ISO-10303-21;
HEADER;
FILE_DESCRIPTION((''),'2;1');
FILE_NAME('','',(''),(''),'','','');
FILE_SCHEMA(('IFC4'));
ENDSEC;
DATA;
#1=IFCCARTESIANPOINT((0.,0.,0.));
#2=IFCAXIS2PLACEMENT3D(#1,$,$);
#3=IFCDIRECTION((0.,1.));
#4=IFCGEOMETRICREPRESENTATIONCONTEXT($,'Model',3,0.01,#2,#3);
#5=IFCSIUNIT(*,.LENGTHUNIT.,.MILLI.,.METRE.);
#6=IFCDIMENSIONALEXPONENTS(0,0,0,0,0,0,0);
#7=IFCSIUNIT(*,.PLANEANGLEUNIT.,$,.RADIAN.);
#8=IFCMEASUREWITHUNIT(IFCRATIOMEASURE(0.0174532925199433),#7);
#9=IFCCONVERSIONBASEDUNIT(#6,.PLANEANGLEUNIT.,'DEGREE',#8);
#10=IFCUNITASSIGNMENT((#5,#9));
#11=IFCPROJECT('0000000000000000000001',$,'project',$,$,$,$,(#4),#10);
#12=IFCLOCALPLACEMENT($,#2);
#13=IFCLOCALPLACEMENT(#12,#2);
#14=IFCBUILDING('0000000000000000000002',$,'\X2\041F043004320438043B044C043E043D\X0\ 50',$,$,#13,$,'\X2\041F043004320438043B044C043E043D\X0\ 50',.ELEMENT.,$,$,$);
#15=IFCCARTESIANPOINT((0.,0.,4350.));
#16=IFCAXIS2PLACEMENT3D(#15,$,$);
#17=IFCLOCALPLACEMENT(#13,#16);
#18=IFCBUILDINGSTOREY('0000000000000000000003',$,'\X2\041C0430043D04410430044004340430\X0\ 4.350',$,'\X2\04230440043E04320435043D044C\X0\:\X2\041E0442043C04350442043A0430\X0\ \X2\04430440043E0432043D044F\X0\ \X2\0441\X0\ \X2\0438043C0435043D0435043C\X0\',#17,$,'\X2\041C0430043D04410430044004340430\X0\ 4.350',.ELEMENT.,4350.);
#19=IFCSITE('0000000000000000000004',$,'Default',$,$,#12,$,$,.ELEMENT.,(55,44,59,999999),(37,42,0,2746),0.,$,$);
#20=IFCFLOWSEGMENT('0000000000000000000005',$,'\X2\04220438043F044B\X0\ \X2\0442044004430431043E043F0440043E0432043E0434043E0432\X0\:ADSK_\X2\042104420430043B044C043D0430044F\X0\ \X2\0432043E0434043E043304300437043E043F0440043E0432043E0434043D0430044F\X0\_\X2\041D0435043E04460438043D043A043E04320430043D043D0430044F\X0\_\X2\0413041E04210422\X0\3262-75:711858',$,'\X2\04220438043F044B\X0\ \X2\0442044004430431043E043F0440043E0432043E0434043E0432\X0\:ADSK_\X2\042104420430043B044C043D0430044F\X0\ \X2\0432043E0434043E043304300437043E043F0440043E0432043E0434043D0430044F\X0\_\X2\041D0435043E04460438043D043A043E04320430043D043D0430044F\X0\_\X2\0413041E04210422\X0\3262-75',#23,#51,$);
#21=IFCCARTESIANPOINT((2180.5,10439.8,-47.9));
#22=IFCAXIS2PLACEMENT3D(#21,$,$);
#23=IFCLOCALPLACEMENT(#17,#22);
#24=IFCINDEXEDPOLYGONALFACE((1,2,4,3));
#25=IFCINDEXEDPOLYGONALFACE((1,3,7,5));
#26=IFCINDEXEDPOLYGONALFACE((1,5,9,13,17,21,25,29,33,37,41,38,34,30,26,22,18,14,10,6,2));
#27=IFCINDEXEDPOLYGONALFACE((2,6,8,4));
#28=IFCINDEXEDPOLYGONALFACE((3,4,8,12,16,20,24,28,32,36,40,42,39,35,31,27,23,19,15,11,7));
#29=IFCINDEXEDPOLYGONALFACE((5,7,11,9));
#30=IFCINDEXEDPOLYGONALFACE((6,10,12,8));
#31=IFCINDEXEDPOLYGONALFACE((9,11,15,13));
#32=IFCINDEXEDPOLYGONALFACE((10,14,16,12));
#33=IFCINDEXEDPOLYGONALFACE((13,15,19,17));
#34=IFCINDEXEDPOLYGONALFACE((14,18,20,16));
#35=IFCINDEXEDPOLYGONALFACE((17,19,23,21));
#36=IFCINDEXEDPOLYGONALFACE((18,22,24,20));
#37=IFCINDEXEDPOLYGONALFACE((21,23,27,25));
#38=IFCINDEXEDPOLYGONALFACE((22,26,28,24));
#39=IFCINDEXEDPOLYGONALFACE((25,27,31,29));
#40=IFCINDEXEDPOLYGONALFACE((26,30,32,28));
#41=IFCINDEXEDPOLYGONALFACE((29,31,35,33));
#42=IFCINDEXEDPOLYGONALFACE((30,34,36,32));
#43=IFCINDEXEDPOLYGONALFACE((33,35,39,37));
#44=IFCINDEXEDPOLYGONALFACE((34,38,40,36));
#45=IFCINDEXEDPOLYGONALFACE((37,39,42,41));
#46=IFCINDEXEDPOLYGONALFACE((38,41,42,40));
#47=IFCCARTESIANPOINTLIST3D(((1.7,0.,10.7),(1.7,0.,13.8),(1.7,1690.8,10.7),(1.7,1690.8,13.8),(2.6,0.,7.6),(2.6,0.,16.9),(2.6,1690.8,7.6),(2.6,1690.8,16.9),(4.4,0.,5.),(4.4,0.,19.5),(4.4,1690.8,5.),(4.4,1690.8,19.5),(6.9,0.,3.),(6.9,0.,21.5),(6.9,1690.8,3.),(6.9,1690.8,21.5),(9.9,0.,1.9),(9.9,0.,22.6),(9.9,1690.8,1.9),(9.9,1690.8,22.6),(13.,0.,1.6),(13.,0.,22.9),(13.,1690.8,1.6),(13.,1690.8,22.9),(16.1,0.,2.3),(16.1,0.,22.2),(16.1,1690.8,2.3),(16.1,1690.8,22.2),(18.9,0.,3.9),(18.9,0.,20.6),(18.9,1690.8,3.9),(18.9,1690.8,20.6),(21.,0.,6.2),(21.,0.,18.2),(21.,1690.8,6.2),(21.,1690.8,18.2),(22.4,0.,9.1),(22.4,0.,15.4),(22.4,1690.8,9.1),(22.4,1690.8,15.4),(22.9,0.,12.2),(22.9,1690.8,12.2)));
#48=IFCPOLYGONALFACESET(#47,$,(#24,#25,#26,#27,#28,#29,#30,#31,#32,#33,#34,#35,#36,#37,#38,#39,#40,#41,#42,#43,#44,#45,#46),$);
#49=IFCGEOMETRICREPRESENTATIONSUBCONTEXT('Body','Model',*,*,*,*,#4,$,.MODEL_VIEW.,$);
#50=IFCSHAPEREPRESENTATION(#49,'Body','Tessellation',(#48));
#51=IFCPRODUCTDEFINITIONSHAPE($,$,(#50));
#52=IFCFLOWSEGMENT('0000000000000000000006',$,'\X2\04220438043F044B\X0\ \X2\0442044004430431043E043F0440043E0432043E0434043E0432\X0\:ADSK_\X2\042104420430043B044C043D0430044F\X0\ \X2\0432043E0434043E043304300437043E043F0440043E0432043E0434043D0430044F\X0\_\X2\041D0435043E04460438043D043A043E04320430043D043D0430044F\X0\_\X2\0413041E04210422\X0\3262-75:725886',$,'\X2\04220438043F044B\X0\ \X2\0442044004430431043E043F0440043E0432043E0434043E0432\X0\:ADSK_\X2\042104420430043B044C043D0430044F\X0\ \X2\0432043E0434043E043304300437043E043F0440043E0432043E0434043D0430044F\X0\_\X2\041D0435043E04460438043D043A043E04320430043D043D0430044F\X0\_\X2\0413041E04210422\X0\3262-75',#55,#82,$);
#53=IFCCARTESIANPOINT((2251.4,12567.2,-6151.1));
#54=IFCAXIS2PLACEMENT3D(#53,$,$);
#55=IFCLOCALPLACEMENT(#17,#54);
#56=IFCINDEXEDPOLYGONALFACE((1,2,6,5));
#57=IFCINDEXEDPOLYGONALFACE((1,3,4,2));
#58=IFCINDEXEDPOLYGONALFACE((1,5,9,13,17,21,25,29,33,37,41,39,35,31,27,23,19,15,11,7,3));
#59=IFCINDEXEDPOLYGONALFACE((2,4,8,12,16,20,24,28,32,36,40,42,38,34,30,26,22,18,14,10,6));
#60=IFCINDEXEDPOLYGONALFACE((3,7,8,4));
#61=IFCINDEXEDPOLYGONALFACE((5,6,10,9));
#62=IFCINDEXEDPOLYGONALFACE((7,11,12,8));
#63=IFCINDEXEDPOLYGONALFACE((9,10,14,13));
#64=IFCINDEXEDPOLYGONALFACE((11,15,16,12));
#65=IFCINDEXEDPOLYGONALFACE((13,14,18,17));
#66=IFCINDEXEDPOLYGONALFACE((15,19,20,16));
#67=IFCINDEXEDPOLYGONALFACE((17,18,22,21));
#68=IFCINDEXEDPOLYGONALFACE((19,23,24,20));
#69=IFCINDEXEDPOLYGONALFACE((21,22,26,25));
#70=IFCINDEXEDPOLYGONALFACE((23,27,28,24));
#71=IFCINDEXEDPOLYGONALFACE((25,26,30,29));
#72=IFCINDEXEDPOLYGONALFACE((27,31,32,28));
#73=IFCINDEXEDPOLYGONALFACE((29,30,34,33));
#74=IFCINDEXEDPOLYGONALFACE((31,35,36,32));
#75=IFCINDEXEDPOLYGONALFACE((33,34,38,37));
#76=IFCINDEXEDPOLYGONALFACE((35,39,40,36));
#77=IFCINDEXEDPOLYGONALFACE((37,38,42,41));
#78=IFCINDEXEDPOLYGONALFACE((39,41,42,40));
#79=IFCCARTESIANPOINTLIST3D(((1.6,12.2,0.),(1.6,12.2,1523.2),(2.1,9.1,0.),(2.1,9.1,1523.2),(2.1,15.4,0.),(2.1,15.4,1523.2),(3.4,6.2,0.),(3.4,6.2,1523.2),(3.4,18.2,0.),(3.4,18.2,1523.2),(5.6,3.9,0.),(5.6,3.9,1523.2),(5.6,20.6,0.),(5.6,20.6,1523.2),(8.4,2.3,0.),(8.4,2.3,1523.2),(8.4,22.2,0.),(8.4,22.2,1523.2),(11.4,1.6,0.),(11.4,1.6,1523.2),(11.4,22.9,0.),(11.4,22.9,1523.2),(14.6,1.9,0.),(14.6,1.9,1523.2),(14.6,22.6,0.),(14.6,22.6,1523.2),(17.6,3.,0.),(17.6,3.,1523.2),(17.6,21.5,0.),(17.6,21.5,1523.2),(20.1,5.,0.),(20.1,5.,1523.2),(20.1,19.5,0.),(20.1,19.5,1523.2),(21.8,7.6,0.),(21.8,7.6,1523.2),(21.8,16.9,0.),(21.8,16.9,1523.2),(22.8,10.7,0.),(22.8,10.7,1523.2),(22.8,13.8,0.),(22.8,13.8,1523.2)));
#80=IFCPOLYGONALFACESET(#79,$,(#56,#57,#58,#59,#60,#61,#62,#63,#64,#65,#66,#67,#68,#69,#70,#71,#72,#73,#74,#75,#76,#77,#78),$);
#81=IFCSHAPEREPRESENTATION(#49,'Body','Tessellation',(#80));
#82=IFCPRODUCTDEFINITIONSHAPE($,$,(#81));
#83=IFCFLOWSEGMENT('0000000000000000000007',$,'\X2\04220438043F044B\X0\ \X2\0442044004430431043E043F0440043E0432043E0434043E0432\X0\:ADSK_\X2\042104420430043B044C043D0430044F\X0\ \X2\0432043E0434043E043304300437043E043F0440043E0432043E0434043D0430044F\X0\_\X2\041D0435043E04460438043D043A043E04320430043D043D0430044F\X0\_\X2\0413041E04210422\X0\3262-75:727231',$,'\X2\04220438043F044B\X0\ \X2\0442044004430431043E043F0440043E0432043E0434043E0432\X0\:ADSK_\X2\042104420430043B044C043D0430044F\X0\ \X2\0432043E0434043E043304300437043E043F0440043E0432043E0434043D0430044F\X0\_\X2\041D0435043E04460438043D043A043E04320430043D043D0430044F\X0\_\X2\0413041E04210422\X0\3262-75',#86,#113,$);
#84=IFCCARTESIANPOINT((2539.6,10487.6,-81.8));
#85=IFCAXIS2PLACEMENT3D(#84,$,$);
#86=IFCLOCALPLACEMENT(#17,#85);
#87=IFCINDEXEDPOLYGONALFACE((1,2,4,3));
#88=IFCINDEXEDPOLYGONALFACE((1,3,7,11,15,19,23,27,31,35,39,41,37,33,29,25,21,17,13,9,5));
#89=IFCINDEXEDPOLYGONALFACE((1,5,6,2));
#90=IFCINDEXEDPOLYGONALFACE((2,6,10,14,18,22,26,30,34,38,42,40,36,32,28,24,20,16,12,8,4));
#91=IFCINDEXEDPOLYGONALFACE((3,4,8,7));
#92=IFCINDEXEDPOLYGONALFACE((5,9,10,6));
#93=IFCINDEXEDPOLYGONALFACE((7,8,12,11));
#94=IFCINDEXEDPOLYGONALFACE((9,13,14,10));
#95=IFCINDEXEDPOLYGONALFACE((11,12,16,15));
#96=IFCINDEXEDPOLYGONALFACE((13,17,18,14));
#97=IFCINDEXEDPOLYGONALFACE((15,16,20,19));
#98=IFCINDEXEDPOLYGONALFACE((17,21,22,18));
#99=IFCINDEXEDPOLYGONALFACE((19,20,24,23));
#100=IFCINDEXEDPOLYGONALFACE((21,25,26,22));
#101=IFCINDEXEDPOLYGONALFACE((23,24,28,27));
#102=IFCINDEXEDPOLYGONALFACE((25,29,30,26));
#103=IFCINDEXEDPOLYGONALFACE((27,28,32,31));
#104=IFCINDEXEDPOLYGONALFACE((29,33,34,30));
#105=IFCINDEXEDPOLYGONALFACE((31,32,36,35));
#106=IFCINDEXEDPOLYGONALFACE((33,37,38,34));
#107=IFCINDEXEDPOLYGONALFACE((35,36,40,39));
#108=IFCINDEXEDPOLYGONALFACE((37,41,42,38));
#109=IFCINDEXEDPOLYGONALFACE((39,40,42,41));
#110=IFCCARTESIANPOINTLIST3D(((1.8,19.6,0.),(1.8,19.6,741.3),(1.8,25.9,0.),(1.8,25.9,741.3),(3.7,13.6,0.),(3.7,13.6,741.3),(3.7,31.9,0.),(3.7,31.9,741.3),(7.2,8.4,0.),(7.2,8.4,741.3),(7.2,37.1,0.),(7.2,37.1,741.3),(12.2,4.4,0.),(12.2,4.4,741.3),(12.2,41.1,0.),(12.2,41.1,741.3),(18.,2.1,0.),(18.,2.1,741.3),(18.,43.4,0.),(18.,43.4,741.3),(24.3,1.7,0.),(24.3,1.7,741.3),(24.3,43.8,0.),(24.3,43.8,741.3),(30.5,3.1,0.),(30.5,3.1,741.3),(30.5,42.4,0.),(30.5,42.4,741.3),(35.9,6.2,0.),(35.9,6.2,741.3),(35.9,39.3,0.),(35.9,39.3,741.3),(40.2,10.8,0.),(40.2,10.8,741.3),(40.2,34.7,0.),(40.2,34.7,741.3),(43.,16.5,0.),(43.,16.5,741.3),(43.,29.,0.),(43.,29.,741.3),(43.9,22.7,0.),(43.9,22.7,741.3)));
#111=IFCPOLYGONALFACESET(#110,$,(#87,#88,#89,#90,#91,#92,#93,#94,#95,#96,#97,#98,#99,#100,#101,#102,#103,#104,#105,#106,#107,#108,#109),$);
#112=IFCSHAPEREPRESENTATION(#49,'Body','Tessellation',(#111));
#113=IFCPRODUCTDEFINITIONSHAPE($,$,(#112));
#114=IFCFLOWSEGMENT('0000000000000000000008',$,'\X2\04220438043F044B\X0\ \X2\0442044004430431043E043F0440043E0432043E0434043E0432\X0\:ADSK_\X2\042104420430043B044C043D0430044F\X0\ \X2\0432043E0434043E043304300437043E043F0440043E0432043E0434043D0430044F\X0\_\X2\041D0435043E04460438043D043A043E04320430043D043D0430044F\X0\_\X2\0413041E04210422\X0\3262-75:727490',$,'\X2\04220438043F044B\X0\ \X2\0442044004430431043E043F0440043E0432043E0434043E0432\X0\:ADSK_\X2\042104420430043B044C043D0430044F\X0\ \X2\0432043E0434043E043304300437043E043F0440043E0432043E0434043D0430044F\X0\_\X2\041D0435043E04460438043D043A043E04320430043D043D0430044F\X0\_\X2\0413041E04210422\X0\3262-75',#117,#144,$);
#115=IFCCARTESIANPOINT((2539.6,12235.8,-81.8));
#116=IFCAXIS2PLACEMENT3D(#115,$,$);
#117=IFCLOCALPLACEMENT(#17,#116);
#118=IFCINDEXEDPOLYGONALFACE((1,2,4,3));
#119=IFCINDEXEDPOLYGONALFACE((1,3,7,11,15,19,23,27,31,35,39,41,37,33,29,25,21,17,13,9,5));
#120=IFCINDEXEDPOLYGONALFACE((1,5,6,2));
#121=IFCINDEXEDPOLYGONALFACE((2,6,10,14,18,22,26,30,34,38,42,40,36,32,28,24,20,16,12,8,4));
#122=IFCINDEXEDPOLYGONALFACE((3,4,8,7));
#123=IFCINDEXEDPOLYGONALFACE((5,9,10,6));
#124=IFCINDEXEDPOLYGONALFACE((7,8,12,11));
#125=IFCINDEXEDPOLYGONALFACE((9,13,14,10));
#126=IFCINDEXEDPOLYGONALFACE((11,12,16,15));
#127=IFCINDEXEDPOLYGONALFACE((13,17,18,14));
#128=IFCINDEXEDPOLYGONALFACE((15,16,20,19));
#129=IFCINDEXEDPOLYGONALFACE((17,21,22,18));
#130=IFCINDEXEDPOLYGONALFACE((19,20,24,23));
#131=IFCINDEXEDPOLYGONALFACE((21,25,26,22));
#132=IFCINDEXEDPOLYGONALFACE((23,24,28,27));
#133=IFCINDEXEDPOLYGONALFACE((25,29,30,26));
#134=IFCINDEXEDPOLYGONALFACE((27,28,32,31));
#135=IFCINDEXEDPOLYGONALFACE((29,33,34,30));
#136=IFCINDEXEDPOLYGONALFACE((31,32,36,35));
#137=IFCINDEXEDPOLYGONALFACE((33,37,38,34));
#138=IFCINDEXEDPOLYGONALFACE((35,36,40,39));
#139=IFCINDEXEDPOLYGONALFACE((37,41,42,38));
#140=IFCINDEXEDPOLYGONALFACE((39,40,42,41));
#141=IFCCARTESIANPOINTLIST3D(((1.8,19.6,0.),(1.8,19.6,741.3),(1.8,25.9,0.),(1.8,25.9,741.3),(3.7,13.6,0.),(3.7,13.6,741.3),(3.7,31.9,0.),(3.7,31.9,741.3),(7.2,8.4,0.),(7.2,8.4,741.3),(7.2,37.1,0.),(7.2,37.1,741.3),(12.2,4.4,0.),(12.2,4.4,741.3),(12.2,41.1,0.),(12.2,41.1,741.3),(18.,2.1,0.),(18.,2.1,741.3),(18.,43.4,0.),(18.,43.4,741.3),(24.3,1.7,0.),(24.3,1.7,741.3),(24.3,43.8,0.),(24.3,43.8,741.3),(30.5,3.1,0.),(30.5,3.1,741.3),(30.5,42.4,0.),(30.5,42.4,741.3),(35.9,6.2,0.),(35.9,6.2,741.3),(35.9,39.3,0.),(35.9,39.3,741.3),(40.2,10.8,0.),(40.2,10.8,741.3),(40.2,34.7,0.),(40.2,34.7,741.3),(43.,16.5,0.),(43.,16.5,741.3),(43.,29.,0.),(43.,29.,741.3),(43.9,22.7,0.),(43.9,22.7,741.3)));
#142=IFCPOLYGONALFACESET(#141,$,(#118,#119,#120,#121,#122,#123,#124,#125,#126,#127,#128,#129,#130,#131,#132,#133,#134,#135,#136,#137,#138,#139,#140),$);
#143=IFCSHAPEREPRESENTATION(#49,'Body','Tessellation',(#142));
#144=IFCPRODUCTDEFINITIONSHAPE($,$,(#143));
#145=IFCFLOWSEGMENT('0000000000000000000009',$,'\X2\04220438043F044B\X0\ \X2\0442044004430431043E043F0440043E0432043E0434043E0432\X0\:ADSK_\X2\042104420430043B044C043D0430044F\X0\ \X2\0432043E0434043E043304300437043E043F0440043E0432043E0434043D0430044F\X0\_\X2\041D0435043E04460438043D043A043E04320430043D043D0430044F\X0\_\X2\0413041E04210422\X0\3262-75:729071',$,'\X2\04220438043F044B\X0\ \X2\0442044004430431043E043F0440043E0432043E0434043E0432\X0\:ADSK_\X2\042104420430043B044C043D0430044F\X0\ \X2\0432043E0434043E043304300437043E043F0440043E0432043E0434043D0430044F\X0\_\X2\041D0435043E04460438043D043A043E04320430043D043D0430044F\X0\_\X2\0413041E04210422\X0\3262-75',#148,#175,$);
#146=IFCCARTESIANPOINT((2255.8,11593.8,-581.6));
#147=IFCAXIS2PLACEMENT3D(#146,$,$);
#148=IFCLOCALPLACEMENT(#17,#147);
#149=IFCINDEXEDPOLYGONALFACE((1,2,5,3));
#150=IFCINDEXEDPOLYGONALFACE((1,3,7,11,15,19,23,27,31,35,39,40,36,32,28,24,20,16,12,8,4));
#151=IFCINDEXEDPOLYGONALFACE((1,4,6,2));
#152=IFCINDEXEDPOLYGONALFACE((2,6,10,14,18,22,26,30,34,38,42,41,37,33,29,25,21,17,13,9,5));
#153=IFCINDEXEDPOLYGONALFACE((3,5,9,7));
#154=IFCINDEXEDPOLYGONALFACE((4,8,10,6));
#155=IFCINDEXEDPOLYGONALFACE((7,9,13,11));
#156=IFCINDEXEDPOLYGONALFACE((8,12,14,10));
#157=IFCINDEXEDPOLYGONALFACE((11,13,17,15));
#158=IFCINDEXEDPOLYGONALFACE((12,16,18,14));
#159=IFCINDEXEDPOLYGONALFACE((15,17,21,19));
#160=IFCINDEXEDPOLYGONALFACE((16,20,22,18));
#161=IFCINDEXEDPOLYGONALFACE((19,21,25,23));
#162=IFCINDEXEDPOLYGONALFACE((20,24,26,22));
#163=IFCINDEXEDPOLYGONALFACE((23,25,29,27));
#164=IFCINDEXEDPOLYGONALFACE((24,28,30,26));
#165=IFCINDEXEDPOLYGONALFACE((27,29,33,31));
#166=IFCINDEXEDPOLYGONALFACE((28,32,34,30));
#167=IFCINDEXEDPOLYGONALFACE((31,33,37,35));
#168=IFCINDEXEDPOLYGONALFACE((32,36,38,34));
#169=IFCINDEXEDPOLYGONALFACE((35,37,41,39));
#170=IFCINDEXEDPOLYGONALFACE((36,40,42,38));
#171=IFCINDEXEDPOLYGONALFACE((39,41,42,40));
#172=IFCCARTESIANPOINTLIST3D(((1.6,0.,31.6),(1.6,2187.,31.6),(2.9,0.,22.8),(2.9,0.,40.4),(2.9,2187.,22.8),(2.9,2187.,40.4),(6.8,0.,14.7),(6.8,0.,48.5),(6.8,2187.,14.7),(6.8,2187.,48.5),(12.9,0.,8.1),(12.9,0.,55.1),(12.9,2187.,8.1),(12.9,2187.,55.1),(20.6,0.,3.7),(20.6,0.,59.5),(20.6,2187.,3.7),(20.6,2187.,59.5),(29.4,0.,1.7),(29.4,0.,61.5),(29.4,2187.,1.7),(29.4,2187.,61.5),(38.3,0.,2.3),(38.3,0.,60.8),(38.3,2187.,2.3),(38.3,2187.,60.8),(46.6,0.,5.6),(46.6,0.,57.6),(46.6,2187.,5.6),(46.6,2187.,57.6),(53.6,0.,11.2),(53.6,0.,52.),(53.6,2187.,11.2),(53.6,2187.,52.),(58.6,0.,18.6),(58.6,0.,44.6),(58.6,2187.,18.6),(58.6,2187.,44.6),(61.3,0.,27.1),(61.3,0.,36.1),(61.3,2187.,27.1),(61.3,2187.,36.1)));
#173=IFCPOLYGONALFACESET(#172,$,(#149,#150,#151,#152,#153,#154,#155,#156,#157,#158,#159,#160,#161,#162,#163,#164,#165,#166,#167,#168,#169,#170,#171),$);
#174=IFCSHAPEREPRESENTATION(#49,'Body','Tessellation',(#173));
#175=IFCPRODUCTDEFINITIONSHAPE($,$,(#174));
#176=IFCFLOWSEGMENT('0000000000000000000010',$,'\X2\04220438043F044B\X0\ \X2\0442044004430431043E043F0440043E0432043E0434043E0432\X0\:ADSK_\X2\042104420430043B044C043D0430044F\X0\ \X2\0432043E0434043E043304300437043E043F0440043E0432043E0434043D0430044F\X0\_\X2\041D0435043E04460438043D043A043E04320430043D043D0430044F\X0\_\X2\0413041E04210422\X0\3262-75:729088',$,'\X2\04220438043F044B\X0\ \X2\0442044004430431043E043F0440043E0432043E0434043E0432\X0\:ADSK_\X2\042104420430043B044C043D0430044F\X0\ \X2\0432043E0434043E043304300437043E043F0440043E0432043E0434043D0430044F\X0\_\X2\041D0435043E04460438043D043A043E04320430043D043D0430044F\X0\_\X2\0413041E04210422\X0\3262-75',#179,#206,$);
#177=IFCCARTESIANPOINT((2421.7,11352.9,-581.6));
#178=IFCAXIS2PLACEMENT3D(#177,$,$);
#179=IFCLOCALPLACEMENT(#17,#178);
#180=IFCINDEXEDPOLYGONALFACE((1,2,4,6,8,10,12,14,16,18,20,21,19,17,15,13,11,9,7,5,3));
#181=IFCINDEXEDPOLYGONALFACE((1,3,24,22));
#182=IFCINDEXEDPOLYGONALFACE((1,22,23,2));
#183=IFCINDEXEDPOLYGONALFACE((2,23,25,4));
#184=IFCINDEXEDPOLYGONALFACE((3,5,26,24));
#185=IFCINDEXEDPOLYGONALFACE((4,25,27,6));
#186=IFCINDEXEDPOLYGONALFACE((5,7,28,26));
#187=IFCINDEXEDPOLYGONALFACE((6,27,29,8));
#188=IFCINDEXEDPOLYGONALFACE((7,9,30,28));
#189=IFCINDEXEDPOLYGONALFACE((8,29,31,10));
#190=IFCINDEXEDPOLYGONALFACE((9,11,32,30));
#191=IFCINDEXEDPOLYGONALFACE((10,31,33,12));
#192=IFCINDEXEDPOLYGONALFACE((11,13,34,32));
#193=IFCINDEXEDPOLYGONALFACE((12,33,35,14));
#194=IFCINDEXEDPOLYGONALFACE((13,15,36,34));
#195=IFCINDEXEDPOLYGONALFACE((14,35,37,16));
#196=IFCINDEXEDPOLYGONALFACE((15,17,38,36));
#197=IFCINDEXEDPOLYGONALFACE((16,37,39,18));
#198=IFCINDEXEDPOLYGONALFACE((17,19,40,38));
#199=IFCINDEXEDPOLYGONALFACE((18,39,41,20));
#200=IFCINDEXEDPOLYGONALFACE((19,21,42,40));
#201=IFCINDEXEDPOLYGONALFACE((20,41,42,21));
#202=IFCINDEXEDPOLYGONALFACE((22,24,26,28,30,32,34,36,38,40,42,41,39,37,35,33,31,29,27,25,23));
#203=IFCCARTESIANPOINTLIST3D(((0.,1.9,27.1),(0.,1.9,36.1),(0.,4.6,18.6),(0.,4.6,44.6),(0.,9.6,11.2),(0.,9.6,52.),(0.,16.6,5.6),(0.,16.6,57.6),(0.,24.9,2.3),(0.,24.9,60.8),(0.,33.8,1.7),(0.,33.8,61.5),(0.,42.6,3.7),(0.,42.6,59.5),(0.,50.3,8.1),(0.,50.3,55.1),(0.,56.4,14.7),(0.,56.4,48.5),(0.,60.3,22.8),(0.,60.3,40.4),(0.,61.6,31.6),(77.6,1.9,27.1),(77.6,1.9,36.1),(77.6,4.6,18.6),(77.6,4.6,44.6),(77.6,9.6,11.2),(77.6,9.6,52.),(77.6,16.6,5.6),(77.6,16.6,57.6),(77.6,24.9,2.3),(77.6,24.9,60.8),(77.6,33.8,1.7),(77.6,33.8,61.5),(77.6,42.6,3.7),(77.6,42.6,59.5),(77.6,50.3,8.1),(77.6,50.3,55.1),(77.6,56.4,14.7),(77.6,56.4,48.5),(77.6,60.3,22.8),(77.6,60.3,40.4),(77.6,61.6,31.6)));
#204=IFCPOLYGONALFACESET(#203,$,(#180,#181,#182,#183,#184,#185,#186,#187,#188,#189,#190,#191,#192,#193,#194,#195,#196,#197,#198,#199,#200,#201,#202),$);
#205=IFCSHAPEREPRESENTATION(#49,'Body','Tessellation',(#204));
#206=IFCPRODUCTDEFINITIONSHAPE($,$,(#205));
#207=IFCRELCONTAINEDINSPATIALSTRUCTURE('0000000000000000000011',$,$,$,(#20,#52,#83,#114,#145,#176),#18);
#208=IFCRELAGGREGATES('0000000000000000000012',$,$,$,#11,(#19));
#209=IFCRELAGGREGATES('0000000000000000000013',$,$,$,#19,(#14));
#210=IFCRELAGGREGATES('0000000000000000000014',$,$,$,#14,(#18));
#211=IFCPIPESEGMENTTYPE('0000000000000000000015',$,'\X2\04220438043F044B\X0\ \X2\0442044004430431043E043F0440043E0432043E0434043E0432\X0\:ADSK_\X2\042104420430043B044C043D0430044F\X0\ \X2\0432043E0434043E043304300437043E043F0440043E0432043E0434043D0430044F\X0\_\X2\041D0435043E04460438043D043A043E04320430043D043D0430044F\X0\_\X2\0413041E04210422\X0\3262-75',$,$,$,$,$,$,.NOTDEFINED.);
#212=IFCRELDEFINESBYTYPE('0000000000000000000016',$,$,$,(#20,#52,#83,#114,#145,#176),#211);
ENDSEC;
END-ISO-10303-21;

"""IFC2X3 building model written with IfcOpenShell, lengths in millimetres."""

from ifc_helpers import new_model, entity, si_unit, converted_unit, direction, frame, frame_2d, origin, origin_2d_with_axis, place, context, subcontext, project, spatial, circle, extrude, type_object, element, save


model = new_model("IFC2X3")

# Units and contexts
model_context = context("Model", 3, precision=0.01, world=origin(), true_north=direction((0.0, 1.0)))
body_context = subcontext(model_context, "Body", "Model", "MODEL_VIEW")
ifc_project = project(units=[si_unit("LENGTHUNIT", "METRE", prefix="MILLI"), converted_unit("PLANEANGLEUNIT", "DEGREE", entity("IfcRatioMeasure", 0.0174532925199433), si_unit("PLANEANGLEUNIT", "RADIAN"), dimensions=[0, 0, 0, 0, 0, 0, 0])], contexts=[model_context])

# Site, building, storey
site_placement = place(None, origin())
site = spatial("IfcSite", under=ifc_project, at=site_placement, Name="Default", CompositionType="ELEMENT", RefLatitude=(55, 44, 59, 999999), RefLongitude=(37, 42, 0, 2746), RefElevation=0.0)
building_placement = place(site_placement, origin())
building = spatial("IfcBuilding", under=site, at=building_placement, Name="Павильон 50", LongName="Павильон 50", CompositionType="ELEMENT")
storey_placement = place(building_placement, frame((0.0, 0.0, 4350.0)))
storey = spatial("IfcBuildingStorey", under=building, at=storey_placement, Name="Мансарда 4.350", ObjectType="Уровень:Отметка уровня с именем", LongName="Мансарда 4.350", CompositionType="ELEMENT", Elevation=4350.0)

# Flow segments
pipe_segment_type = type_object("IfcPipeSegmentType", Name="Типы трубопроводов:ADSK_Стальная водогазопроводная_Неоцинкованная_ГОСТ3262-75", PredefinedType="NOTDEFINED")
flow_segment_1_placement = place(storey_placement, frame((2180.5, 10439.8, -47.9)))
element("IfcFlowSegment", 1, at=flow_segment_1_placement, inside=storey, type_object=pipe_segment_type, Name="Типы трубопроводов:ADSK_Стальная водогазопроводная_Неоцинкованная_ГОСТ3262-75:711858", ObjectType="Типы трубопроводов:ADSK_Стальная водогазопроводная_Неоцинкованная_ГОСТ3262-75", context=body_context, shape_type="SweptSolid", body=[
    extrude(circle(Radius=10.7, at=origin_2d_with_axis()), frame((12.2, 0.0, 12.2), z_axis=(0.0, 1.0, 0.0), x_axis=(1.0, 0.0, 0.0)), (0.0, 0.0, 1.0), 1690.8),
])
flow_segment_2_placement = place(storey_placement, frame((2251.4, 12567.2, -6151.1)))
element("IfcFlowSegment", 2, at=flow_segment_2_placement, inside=storey, type_object=pipe_segment_type, Name="Типы трубопроводов:ADSK_Стальная водогазопроводная_Неоцинкованная_ГОСТ3262-75:725886", ObjectType="Типы трубопроводов:ADSK_Стальная водогазопроводная_Неоцинкованная_ГОСТ3262-75", context=body_context, shape_type="SweptSolid", body=[
    extrude(circle(Radius=10.7, at=origin_2d_with_axis()), frame((12.2, 12.2, 0.0), z_axis=(0.0, 0.0, 1.0), x_axis=(-1.0, 0.0, 0.0)), (0.0, 0.0, 1.0), 1523.2),
])
flow_segment_3_placement = place(storey_placement, frame((2539.6, 10487.6, -81.8)))
element("IfcFlowSegment", 3, at=flow_segment_3_placement, inside=storey, type_object=pipe_segment_type, Name="Типы трубопроводов:ADSK_Стальная водогазопроводная_Неоцинкованная_ГОСТ3262-75:727231", ObjectType="Типы трубопроводов:ADSK_Стальная водогазопроводная_Неоцинкованная_ГОСТ3262-75", context=body_context, shape_type="SweptSolid", body=[
    extrude(circle(Radius=21.1, at=origin_2d_with_axis()), frame((22.7, 22.7, 0.0)), (0.0, 0.0, 1.0), 741.3),
])
flow_segment_4_placement = place(storey_placement, frame((2539.6, 12235.8, -81.8)))
element("IfcFlowSegment", 4, at=flow_segment_4_placement, inside=storey, type_object=pipe_segment_type, Name="Типы трубопроводов:ADSK_Стальная водогазопроводная_Неоцинкованная_ГОСТ3262-75:727490", ObjectType="Типы трубопроводов:ADSK_Стальная водогазопроводная_Неоцинкованная_ГОСТ3262-75", context=body_context, shape_type="SweptSolid", body=[
    extrude(circle(Radius=21.1, at=origin_2d_with_axis()), frame((22.7, 22.7, 0.0)), (0.0, 0.0, 1.0), 741.3),
])
flow_segment_5_placement = place(storey_placement, frame((2255.8, 11593.8, -581.6)))
element("IfcFlowSegment", 5, at=flow_segment_5_placement, inside=storey, type_object=pipe_segment_type, Name="Типы трубопроводов:ADSK_Стальная водогазопроводная_Неоцинкованная_ГОСТ3262-75:729071", ObjectType="Типы трубопроводов:ADSK_Стальная водогазопроводная_Неоцинкованная_ГОСТ3262-75", context=body_context, shape_type="SweptSolid", body=[
    extrude(circle(Radius=30.0, at=frame_2d((0.0, 0.0), x_axis=(1.0, 0.0))), frame((31.6, 0.0, 31.6), z_axis=(0.0, 1.0, 0.0), x_axis=(-1.0, 0.0, 0.0)), (0.0, 0.0, 1.0), 2187.0),
])
flow_segment_6_placement = place(storey_placement, frame((2421.7, 11352.9, -581.6)))
element("IfcFlowSegment", 6, at=flow_segment_6_placement, inside=storey, type_object=pipe_segment_type, Name="Типы трубопроводов:ADSK_Стальная водогазопроводная_Неоцинкованная_ГОСТ3262-75:729088", ObjectType="Типы трубопроводов:ADSK_Стальная водогазопроводная_Неоцинкованная_ГОСТ3262-75", context=body_context, shape_type="SweptSolid", body=[
    extrude(circle(Radius=30.0, at=frame_2d((0.0, 0.0), x_axis=(1.0, 0.0))), frame((0.0, 31.6, 31.6), z_axis=(1.0, 0.0, 0.0), x_axis=(0.0, 1.0, 0.0)), (0.0, 0.0, 1.0), 77.6),
])

save(model, "model.ifc")
